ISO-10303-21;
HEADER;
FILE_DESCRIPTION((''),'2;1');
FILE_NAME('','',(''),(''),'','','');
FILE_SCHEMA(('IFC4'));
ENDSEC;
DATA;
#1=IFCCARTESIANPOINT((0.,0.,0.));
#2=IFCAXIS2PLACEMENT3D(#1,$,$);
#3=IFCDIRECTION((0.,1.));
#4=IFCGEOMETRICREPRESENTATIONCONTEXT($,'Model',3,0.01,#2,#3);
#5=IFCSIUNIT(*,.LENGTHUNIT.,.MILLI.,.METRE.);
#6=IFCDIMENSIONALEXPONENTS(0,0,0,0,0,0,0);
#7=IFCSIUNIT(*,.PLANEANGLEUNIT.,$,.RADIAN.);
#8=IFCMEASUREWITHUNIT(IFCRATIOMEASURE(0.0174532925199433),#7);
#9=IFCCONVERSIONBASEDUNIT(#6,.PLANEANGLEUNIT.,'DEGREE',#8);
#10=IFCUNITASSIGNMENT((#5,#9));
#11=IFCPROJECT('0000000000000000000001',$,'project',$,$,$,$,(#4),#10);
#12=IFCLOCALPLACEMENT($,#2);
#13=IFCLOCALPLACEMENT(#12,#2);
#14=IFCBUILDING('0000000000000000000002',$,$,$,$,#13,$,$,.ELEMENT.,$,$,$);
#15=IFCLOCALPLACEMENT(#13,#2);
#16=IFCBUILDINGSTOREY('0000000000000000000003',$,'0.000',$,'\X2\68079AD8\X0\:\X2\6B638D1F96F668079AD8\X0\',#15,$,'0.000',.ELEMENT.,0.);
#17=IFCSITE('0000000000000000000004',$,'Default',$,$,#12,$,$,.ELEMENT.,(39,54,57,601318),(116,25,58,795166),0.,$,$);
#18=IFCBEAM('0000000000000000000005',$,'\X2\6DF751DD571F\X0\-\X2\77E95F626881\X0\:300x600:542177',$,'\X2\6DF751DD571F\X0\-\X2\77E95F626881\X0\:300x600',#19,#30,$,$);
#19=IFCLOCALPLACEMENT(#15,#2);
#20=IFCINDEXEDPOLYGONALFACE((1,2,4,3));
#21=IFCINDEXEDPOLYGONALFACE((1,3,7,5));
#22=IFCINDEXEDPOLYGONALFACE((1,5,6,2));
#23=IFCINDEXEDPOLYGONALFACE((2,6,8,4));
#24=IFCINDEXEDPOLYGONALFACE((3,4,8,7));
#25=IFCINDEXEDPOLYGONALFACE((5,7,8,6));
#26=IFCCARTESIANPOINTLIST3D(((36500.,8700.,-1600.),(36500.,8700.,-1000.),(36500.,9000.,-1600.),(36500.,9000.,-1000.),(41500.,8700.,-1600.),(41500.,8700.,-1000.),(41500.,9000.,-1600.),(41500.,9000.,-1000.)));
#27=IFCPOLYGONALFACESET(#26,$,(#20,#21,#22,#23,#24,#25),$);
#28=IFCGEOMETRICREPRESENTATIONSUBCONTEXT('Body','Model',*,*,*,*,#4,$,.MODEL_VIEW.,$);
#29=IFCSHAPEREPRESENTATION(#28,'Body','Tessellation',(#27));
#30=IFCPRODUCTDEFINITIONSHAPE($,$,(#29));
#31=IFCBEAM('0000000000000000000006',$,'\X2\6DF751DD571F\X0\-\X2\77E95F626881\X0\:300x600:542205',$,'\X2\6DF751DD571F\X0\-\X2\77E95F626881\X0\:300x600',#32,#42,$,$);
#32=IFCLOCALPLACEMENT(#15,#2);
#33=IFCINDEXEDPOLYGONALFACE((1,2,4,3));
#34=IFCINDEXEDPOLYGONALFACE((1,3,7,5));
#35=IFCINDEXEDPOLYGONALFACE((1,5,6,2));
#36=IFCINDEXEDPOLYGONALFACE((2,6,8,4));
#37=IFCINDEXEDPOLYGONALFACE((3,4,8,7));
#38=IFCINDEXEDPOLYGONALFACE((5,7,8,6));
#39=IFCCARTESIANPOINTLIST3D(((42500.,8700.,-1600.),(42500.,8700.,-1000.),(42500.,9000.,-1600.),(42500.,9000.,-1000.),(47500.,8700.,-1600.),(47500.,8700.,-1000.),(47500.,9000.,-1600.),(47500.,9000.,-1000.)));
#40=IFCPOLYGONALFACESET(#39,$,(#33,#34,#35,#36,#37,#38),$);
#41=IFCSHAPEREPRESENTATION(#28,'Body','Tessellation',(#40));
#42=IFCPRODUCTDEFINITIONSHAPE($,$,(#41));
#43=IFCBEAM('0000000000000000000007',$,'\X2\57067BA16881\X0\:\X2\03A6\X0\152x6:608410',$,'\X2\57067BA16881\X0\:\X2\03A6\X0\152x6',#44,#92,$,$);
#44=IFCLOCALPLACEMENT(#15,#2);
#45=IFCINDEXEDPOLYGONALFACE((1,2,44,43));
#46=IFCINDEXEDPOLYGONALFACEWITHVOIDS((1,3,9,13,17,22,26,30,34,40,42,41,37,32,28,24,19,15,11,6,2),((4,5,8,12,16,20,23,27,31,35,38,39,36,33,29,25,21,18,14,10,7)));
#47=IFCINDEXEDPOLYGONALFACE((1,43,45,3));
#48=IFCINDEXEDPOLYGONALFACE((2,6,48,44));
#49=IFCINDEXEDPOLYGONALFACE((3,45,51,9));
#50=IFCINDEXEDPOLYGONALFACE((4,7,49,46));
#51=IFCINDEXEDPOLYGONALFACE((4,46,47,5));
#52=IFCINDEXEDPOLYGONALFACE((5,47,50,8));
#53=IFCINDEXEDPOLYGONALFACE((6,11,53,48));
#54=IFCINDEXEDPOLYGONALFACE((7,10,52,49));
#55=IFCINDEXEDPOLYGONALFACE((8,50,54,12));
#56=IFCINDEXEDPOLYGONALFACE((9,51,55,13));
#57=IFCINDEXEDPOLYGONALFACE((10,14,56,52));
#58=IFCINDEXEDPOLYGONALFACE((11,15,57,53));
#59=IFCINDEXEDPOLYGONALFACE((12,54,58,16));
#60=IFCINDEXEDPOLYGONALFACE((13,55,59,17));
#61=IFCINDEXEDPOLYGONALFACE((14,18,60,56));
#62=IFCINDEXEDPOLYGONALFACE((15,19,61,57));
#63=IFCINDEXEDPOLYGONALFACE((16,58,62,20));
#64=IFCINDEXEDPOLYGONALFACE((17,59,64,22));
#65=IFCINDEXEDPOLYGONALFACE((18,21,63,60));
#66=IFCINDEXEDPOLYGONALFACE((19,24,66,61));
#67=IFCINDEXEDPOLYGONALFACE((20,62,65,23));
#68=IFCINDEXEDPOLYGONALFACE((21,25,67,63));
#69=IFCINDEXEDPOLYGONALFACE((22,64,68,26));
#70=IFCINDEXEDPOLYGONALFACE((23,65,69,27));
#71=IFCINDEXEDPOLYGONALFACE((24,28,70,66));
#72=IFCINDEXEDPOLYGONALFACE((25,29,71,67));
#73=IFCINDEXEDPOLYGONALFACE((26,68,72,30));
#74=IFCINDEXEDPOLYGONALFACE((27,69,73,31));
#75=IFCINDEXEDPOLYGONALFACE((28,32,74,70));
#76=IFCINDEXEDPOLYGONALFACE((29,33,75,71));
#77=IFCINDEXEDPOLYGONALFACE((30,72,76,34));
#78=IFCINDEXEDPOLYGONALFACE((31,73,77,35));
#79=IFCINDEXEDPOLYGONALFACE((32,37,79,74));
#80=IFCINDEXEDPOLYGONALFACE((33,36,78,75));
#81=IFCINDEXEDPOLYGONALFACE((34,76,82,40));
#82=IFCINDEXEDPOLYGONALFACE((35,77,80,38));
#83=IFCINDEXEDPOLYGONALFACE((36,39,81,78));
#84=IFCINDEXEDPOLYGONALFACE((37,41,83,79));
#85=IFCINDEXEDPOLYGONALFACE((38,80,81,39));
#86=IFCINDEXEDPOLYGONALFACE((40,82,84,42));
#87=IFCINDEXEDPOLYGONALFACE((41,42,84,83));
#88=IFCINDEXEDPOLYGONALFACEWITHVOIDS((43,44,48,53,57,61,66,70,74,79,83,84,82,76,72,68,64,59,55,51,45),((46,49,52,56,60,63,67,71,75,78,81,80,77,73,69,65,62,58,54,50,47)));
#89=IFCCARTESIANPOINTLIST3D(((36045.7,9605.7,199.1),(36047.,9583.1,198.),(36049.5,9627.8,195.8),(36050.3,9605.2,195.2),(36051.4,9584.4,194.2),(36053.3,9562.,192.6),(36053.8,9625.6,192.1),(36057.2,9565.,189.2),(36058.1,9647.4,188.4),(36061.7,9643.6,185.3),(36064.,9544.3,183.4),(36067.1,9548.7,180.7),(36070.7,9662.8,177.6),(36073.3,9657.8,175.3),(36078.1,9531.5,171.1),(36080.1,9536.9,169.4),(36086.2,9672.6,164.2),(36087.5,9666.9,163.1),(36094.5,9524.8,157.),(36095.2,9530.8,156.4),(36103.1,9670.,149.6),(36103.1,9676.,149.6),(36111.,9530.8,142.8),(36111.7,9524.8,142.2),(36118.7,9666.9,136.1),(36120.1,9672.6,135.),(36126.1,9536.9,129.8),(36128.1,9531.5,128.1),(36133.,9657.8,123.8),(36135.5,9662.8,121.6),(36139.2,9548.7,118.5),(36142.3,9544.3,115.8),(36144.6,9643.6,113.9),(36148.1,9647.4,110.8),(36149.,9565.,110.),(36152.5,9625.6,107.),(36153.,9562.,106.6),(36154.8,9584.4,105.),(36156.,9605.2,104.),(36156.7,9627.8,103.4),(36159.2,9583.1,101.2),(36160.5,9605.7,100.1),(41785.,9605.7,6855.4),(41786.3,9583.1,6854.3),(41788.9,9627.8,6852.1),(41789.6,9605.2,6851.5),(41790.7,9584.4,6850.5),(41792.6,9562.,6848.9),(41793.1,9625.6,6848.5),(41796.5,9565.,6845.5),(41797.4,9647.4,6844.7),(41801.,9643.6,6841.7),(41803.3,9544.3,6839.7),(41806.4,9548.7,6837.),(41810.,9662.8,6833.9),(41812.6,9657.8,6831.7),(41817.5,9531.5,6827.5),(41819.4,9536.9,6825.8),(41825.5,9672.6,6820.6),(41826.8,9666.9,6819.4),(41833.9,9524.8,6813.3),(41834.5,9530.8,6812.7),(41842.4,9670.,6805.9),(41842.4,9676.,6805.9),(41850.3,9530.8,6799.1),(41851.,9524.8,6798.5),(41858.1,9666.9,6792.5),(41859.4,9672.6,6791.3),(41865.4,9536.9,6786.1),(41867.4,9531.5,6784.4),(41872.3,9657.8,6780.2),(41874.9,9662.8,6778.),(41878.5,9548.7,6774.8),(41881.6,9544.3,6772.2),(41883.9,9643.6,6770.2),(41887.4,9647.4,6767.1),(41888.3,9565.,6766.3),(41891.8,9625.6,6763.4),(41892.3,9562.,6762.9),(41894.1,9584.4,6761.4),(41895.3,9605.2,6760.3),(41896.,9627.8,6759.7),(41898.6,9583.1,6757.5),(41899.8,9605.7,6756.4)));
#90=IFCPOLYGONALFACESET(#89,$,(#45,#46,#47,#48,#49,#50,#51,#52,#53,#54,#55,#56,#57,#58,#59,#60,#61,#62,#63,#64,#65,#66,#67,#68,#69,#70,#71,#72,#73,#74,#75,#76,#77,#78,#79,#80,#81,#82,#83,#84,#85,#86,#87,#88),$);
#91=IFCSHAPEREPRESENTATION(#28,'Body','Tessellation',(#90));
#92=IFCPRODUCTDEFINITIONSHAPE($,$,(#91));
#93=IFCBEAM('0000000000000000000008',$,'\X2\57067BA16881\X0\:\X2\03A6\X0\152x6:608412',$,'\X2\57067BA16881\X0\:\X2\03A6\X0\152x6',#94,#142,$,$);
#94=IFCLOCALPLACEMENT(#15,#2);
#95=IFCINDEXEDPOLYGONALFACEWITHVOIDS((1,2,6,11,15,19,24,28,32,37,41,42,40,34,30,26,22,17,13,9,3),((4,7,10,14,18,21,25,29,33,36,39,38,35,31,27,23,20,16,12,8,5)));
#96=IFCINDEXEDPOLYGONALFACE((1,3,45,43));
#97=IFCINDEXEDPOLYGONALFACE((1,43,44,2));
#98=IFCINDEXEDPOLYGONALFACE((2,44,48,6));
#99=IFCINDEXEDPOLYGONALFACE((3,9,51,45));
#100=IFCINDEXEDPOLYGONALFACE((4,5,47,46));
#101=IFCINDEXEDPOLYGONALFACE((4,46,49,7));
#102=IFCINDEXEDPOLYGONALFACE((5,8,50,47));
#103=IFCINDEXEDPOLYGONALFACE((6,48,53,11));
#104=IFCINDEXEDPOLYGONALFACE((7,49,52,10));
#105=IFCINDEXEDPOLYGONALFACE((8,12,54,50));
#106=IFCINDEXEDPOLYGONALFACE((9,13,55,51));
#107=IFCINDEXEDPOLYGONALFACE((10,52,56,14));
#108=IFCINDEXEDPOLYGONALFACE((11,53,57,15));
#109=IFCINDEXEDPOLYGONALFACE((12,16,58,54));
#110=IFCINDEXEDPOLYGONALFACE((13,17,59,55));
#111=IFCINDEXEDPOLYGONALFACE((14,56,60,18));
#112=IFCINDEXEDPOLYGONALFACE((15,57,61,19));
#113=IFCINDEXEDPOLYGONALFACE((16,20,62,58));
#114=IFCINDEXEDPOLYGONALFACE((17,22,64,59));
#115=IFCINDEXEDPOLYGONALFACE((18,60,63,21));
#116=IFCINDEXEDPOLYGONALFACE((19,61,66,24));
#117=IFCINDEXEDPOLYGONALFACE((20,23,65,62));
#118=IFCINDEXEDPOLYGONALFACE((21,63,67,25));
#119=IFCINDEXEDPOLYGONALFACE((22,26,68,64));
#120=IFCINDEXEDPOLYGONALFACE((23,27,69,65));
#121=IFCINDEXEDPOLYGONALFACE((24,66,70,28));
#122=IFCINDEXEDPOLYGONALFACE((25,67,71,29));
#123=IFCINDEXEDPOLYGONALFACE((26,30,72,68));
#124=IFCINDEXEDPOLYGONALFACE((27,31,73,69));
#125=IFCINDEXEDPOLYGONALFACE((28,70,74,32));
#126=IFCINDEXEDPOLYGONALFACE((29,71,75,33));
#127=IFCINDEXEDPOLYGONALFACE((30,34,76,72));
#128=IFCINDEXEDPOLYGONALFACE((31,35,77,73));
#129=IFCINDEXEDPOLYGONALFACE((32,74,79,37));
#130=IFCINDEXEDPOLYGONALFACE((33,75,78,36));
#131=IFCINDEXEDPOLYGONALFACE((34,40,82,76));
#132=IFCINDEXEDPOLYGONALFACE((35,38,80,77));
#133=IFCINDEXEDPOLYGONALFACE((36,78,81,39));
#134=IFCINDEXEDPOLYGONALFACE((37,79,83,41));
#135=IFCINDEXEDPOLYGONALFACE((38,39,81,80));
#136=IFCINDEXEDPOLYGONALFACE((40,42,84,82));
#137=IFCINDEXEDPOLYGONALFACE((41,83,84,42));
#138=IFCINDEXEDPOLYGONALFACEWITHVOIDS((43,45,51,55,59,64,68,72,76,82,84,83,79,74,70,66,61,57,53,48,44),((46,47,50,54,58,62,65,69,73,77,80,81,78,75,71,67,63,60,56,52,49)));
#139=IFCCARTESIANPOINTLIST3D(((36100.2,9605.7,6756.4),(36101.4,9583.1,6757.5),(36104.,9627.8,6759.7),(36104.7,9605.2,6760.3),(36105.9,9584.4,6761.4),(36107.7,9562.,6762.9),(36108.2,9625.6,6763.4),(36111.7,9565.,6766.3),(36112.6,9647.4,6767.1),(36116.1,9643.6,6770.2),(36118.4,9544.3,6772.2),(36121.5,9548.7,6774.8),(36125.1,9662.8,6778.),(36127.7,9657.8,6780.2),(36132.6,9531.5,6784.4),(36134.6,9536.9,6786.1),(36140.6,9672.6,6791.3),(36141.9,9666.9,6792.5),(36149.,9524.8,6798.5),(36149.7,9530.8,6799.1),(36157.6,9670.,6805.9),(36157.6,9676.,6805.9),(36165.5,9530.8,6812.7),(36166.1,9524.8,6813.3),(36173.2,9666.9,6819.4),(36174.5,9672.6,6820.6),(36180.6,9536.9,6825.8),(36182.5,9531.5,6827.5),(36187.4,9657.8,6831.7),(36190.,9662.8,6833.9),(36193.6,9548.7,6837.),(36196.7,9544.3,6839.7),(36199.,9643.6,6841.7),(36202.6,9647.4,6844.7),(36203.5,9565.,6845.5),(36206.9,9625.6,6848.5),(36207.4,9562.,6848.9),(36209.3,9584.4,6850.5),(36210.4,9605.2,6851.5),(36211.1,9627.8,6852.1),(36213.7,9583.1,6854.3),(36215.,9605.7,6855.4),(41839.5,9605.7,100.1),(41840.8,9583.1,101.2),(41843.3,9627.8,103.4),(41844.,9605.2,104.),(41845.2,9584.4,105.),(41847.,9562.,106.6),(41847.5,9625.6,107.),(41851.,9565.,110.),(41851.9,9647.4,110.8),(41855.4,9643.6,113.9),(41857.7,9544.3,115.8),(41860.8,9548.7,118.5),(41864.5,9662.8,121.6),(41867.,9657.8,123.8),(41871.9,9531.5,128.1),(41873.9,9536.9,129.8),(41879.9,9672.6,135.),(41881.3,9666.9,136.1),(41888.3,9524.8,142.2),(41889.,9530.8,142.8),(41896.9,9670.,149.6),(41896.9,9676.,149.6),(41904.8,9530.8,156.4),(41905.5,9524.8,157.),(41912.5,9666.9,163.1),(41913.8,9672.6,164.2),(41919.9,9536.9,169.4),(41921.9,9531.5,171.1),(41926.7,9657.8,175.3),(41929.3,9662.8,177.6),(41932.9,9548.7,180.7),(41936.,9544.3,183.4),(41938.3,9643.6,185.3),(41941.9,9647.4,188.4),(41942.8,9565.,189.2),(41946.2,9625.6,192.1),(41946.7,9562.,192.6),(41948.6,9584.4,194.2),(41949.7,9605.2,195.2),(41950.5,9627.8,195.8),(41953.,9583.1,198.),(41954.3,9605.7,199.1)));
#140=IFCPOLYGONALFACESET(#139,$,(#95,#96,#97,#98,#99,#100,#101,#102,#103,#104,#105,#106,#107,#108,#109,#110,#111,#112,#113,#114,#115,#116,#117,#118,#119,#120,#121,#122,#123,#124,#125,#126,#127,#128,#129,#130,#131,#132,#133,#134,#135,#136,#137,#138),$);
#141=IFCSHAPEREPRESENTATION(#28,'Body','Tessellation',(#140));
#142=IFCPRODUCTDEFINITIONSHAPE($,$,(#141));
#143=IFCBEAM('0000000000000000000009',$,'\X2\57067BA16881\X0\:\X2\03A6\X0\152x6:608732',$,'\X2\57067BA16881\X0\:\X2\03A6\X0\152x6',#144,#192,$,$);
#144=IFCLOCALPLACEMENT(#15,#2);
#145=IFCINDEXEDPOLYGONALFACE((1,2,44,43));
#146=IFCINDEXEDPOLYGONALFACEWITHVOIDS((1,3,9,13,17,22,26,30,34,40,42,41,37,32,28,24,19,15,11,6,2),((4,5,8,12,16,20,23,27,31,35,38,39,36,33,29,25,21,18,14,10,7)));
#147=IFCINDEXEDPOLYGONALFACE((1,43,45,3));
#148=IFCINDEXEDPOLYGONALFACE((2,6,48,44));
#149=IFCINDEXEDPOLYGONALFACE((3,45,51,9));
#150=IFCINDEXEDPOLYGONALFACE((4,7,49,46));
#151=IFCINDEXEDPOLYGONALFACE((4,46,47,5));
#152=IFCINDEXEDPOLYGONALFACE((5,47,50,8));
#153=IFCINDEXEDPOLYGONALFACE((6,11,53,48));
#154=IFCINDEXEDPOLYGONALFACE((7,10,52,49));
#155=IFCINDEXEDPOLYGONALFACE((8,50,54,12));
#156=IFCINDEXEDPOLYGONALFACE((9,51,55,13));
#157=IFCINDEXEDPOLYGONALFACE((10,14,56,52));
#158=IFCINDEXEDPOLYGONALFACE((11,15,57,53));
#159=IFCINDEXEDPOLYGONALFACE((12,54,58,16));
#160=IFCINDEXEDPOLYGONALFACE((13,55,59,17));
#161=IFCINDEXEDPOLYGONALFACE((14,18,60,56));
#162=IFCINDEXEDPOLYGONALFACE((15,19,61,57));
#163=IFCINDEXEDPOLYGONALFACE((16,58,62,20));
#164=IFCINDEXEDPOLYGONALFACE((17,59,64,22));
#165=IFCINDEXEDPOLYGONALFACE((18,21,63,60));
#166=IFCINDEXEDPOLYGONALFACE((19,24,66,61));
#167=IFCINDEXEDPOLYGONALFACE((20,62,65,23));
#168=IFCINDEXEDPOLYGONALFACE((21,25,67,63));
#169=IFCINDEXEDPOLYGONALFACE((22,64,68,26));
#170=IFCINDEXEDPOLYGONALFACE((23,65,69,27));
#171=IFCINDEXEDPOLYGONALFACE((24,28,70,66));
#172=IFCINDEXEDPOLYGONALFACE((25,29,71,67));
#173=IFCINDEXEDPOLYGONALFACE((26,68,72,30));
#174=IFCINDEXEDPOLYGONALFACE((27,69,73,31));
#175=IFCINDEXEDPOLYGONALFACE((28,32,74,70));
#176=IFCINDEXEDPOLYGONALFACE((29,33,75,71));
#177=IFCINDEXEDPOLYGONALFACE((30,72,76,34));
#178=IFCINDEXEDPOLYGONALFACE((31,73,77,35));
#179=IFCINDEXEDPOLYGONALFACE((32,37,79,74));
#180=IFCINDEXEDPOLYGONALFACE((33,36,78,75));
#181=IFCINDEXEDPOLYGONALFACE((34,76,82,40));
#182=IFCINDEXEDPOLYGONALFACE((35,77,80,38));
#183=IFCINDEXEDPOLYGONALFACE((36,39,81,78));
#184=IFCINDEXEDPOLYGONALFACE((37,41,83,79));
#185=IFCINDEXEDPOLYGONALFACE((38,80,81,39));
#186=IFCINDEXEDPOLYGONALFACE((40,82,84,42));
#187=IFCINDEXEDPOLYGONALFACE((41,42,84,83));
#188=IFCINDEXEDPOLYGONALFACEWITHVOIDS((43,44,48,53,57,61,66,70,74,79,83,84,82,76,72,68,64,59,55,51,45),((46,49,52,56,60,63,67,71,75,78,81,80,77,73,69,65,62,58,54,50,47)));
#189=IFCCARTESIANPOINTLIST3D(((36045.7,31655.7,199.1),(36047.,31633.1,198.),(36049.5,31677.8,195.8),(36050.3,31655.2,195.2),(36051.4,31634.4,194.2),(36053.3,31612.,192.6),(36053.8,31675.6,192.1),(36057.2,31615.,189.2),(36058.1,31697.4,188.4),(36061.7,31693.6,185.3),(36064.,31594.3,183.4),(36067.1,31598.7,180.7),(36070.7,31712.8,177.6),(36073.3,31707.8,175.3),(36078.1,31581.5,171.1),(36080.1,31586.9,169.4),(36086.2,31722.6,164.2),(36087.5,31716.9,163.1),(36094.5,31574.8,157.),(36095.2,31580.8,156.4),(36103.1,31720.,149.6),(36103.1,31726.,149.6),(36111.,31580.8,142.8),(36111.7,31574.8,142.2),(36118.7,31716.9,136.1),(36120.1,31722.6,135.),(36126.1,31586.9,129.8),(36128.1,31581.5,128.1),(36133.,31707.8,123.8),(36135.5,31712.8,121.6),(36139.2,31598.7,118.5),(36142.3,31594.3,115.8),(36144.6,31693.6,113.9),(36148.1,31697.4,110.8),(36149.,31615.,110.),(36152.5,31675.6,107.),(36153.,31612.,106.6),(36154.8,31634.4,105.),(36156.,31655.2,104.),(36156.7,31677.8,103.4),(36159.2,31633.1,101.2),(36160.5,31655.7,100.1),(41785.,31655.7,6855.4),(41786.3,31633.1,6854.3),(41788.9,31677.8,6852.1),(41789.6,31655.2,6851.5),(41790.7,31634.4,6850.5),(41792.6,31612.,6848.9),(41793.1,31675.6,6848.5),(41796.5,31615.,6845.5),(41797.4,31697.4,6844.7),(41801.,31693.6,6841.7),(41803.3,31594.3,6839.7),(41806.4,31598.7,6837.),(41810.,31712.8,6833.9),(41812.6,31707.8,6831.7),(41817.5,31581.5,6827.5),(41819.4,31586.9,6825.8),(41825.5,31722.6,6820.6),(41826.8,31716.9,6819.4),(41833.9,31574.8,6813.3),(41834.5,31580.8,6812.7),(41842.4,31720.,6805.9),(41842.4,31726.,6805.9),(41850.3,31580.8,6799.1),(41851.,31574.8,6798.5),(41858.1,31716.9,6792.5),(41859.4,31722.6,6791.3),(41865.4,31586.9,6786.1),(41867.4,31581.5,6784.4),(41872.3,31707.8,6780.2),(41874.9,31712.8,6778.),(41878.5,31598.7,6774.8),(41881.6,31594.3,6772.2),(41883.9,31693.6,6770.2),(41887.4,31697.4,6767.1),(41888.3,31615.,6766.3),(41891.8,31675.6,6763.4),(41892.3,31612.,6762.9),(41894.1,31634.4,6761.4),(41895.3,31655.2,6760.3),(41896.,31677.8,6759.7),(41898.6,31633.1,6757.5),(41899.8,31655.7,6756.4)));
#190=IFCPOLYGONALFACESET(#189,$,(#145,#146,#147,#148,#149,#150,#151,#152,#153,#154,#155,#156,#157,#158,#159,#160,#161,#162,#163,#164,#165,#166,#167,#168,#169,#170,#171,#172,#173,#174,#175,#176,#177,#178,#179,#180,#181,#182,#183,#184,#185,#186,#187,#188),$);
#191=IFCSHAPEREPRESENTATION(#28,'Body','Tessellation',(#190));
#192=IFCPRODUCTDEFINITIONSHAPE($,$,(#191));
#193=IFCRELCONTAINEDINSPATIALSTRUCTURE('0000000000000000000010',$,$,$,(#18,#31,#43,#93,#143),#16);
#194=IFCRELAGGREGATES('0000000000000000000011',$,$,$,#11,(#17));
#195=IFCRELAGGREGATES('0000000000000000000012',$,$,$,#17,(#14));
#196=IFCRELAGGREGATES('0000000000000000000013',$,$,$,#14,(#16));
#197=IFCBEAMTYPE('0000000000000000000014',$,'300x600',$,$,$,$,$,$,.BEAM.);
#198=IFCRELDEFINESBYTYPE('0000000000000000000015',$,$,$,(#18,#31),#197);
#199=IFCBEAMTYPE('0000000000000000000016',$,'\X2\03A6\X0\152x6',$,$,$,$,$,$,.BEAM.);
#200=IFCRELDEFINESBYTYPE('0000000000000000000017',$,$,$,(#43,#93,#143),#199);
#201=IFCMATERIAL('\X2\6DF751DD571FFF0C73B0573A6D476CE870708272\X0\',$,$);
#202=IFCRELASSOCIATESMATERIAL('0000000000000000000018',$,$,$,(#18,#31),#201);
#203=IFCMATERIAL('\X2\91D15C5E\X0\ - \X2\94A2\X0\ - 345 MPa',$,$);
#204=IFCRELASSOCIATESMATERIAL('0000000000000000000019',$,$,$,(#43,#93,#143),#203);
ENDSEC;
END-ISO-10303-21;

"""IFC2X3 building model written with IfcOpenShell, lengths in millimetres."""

from ifc_helpers import new_model, entity, si_unit, converted_unit, direction, frame, frame_2d, origin, place, context, subcontext, project, spatial, rectangle, hollow_circle, extrude, material, type_object, element, save


model = new_model("IFC2X3")

# Units and contexts
model_context = context("Model", 3, precision=0.01, world=origin(), true_north=direction((0.0, 1.0)))
body_context = subcontext(model_context, "Body", "Model", "MODEL_VIEW")
ifc_project = project(units=[si_unit("LENGTHUNIT", "METRE", prefix="MILLI"), converted_unit("PLANEANGLEUNIT", "DEGREE", entity("IfcRatioMeasure", 0.0174532925199433), si_unit("PLANEANGLEUNIT", "RADIAN"), dimensions=[0, 0, 0, 0, 0, 0, 0])], contexts=[model_context])

# Site, building, storey
site_placement = place(None, origin())
site = spatial("IfcSite", under=ifc_project, at=site_placement, Name="Default", CompositionType="ELEMENT", RefLatitude=(39, 54, 57, 601318), RefLongitude=(116, 25, 58, 795166), RefElevation=0.0)
building_placement = place(site_placement, origin())
building = spatial("IfcBuilding", under=site, at=building_placement, CompositionType="ELEMENT")
storey_placement = place(building_placement, origin())
storey = spatial("IfcBuildingStorey", under=building, at=storey_placement, Name="0.000", ObjectType="标高:正负零标高", LongName="0.000", CompositionType="ELEMENT", Elevation=0.0)

# Shared definitions
ifc_material_1 = material(Name="金属 - 钢 - 345 MPa")

# Beams
ifc_material_2 = material(Name="混凝土，现场浇注灰色")
beam_type_1 = type_object("IfcBeamType", Name="300x600", PredefinedType="BEAM")
beam_1_placement = place(storey_placement, frame((36500.0, 9000.0, 0.0)))
element("IfcBeam", 1, at=beam_1_placement, inside=storey, type_object=beam_type_1, material=ifc_material_2, Name="混凝土-矩形梁:300x600:542177", ObjectType="混凝土-矩形梁:300x600", context=body_context, shape_type="SweptSolid", body=[
    extrude(rectangle(XDim=600.0, YDim=300.0, at=frame_2d((0.0, 0.0), x_axis=(1.0, 0.0))), frame((0.0, -150.0, -1300.0), z_axis=(1.0, 0.0, 0.0), x_axis=(0.0, 0.0, -1.0)), (0.0, 0.0, 1.0), 5000.0),
])
beam_2_placement = place(storey_placement, frame((42500.0, 9000.0, 0.0)))
element("IfcBeam", 2, at=beam_2_placement, inside=storey, type_object=beam_type_1, material=ifc_material_2, Name="混凝土-矩形梁:300x600:542205", ObjectType="混凝土-矩形梁:300x600", context=body_context, shape_type="SweptSolid", body=[
    extrude(rectangle(XDim=600.0, YDim=300.0, at=frame_2d((0.0, 0.0), x_axis=(1.0, 0.0))), frame((0.0, -150.0, -1300.0), z_axis=(1.0, 0.0, 0.0), x_axis=(0.0, 0.0, -1.0)), (0.0, 0.0, 1.0), 5000.0),
])
beam_type_2 = type_object("IfcBeamType", Name="Φ152x6", PredefinedType="BEAM")
beam_3_placement = place(storey_placement, frame((36138.2, 9600.0, -116.0), z_axis=(0.757348, 0.0, -0.653011), x_axis=(0.653011, 0.0, 0.757348)))
element("IfcBeam", 3, at=beam_3_placement, inside=storey, type_object=beam_type_2, material=ifc_material_1, Name="圆管梁:Φ152x6:608410", ObjectType="圆管梁:Φ152x6", context=body_context, shape_type="SweptSolid", body=[
    extrude(hollow_circle(Radius=76.0, WallThickness=6.0, at=frame_2d((0.0, 0.0), x_axis=(1.0, 0.0))), frame((178.3, 0.0, -200.0), z_axis=(1.0, 0.0, 0.0), x_axis=(0.0, -1.0, 0.0)), (0.0, 0.0, 1.0), 8789.0),
])
beam_4_placement = place(storey_placement, frame((41861.8, 9600.0, -116.0), z_axis=(0.757348, 0.0, 0.653011), x_axis=(-0.653011, 0.0, 0.757348)))
element("IfcBeam", 4, at=beam_4_placement, inside=storey, type_object=beam_type_2, material=ifc_material_1, Name="圆管梁:Φ152x6:608412", ObjectType="圆管梁:Φ152x6", context=body_context, shape_type="SweptSolid", body=[
    extrude(hollow_circle(Radius=76.0, WallThickness=6.0, at=frame_2d((0.0, 0.0), x_axis=(1.0, 0.0))), frame((178.3, 0.0, 200.0), z_axis=(1.0, 0.0, 0.0), x_axis=(0.0, -1.0, 0.0)), (0.0, 0.0, 1.0), 8789.0),
])
beam_5_placement = place(storey_placement, frame((36138.2, 31650.0, -116.0), z_axis=(0.757348, 0.0, -0.653011), x_axis=(0.653011, 0.0, 0.757348)))
element("IfcBeam", 5, at=beam_5_placement, inside=storey, type_object=beam_type_2, material=ifc_material_1, Name="圆管梁:Φ152x6:608732", ObjectType="圆管梁:Φ152x6", context=body_context, shape_type="SweptSolid", body=[
    extrude(hollow_circle(Radius=76.0, WallThickness=6.0, at=frame_2d((0.0, 0.0), x_axis=(1.0, 0.0))), frame((178.3, 0.0, -200.0), z_axis=(1.0, 0.0, 0.0), x_axis=(0.0, -1.0, 0.0)), (0.0, 0.0, 1.0), 8789.0),
])

save(model, "model.ifc")
